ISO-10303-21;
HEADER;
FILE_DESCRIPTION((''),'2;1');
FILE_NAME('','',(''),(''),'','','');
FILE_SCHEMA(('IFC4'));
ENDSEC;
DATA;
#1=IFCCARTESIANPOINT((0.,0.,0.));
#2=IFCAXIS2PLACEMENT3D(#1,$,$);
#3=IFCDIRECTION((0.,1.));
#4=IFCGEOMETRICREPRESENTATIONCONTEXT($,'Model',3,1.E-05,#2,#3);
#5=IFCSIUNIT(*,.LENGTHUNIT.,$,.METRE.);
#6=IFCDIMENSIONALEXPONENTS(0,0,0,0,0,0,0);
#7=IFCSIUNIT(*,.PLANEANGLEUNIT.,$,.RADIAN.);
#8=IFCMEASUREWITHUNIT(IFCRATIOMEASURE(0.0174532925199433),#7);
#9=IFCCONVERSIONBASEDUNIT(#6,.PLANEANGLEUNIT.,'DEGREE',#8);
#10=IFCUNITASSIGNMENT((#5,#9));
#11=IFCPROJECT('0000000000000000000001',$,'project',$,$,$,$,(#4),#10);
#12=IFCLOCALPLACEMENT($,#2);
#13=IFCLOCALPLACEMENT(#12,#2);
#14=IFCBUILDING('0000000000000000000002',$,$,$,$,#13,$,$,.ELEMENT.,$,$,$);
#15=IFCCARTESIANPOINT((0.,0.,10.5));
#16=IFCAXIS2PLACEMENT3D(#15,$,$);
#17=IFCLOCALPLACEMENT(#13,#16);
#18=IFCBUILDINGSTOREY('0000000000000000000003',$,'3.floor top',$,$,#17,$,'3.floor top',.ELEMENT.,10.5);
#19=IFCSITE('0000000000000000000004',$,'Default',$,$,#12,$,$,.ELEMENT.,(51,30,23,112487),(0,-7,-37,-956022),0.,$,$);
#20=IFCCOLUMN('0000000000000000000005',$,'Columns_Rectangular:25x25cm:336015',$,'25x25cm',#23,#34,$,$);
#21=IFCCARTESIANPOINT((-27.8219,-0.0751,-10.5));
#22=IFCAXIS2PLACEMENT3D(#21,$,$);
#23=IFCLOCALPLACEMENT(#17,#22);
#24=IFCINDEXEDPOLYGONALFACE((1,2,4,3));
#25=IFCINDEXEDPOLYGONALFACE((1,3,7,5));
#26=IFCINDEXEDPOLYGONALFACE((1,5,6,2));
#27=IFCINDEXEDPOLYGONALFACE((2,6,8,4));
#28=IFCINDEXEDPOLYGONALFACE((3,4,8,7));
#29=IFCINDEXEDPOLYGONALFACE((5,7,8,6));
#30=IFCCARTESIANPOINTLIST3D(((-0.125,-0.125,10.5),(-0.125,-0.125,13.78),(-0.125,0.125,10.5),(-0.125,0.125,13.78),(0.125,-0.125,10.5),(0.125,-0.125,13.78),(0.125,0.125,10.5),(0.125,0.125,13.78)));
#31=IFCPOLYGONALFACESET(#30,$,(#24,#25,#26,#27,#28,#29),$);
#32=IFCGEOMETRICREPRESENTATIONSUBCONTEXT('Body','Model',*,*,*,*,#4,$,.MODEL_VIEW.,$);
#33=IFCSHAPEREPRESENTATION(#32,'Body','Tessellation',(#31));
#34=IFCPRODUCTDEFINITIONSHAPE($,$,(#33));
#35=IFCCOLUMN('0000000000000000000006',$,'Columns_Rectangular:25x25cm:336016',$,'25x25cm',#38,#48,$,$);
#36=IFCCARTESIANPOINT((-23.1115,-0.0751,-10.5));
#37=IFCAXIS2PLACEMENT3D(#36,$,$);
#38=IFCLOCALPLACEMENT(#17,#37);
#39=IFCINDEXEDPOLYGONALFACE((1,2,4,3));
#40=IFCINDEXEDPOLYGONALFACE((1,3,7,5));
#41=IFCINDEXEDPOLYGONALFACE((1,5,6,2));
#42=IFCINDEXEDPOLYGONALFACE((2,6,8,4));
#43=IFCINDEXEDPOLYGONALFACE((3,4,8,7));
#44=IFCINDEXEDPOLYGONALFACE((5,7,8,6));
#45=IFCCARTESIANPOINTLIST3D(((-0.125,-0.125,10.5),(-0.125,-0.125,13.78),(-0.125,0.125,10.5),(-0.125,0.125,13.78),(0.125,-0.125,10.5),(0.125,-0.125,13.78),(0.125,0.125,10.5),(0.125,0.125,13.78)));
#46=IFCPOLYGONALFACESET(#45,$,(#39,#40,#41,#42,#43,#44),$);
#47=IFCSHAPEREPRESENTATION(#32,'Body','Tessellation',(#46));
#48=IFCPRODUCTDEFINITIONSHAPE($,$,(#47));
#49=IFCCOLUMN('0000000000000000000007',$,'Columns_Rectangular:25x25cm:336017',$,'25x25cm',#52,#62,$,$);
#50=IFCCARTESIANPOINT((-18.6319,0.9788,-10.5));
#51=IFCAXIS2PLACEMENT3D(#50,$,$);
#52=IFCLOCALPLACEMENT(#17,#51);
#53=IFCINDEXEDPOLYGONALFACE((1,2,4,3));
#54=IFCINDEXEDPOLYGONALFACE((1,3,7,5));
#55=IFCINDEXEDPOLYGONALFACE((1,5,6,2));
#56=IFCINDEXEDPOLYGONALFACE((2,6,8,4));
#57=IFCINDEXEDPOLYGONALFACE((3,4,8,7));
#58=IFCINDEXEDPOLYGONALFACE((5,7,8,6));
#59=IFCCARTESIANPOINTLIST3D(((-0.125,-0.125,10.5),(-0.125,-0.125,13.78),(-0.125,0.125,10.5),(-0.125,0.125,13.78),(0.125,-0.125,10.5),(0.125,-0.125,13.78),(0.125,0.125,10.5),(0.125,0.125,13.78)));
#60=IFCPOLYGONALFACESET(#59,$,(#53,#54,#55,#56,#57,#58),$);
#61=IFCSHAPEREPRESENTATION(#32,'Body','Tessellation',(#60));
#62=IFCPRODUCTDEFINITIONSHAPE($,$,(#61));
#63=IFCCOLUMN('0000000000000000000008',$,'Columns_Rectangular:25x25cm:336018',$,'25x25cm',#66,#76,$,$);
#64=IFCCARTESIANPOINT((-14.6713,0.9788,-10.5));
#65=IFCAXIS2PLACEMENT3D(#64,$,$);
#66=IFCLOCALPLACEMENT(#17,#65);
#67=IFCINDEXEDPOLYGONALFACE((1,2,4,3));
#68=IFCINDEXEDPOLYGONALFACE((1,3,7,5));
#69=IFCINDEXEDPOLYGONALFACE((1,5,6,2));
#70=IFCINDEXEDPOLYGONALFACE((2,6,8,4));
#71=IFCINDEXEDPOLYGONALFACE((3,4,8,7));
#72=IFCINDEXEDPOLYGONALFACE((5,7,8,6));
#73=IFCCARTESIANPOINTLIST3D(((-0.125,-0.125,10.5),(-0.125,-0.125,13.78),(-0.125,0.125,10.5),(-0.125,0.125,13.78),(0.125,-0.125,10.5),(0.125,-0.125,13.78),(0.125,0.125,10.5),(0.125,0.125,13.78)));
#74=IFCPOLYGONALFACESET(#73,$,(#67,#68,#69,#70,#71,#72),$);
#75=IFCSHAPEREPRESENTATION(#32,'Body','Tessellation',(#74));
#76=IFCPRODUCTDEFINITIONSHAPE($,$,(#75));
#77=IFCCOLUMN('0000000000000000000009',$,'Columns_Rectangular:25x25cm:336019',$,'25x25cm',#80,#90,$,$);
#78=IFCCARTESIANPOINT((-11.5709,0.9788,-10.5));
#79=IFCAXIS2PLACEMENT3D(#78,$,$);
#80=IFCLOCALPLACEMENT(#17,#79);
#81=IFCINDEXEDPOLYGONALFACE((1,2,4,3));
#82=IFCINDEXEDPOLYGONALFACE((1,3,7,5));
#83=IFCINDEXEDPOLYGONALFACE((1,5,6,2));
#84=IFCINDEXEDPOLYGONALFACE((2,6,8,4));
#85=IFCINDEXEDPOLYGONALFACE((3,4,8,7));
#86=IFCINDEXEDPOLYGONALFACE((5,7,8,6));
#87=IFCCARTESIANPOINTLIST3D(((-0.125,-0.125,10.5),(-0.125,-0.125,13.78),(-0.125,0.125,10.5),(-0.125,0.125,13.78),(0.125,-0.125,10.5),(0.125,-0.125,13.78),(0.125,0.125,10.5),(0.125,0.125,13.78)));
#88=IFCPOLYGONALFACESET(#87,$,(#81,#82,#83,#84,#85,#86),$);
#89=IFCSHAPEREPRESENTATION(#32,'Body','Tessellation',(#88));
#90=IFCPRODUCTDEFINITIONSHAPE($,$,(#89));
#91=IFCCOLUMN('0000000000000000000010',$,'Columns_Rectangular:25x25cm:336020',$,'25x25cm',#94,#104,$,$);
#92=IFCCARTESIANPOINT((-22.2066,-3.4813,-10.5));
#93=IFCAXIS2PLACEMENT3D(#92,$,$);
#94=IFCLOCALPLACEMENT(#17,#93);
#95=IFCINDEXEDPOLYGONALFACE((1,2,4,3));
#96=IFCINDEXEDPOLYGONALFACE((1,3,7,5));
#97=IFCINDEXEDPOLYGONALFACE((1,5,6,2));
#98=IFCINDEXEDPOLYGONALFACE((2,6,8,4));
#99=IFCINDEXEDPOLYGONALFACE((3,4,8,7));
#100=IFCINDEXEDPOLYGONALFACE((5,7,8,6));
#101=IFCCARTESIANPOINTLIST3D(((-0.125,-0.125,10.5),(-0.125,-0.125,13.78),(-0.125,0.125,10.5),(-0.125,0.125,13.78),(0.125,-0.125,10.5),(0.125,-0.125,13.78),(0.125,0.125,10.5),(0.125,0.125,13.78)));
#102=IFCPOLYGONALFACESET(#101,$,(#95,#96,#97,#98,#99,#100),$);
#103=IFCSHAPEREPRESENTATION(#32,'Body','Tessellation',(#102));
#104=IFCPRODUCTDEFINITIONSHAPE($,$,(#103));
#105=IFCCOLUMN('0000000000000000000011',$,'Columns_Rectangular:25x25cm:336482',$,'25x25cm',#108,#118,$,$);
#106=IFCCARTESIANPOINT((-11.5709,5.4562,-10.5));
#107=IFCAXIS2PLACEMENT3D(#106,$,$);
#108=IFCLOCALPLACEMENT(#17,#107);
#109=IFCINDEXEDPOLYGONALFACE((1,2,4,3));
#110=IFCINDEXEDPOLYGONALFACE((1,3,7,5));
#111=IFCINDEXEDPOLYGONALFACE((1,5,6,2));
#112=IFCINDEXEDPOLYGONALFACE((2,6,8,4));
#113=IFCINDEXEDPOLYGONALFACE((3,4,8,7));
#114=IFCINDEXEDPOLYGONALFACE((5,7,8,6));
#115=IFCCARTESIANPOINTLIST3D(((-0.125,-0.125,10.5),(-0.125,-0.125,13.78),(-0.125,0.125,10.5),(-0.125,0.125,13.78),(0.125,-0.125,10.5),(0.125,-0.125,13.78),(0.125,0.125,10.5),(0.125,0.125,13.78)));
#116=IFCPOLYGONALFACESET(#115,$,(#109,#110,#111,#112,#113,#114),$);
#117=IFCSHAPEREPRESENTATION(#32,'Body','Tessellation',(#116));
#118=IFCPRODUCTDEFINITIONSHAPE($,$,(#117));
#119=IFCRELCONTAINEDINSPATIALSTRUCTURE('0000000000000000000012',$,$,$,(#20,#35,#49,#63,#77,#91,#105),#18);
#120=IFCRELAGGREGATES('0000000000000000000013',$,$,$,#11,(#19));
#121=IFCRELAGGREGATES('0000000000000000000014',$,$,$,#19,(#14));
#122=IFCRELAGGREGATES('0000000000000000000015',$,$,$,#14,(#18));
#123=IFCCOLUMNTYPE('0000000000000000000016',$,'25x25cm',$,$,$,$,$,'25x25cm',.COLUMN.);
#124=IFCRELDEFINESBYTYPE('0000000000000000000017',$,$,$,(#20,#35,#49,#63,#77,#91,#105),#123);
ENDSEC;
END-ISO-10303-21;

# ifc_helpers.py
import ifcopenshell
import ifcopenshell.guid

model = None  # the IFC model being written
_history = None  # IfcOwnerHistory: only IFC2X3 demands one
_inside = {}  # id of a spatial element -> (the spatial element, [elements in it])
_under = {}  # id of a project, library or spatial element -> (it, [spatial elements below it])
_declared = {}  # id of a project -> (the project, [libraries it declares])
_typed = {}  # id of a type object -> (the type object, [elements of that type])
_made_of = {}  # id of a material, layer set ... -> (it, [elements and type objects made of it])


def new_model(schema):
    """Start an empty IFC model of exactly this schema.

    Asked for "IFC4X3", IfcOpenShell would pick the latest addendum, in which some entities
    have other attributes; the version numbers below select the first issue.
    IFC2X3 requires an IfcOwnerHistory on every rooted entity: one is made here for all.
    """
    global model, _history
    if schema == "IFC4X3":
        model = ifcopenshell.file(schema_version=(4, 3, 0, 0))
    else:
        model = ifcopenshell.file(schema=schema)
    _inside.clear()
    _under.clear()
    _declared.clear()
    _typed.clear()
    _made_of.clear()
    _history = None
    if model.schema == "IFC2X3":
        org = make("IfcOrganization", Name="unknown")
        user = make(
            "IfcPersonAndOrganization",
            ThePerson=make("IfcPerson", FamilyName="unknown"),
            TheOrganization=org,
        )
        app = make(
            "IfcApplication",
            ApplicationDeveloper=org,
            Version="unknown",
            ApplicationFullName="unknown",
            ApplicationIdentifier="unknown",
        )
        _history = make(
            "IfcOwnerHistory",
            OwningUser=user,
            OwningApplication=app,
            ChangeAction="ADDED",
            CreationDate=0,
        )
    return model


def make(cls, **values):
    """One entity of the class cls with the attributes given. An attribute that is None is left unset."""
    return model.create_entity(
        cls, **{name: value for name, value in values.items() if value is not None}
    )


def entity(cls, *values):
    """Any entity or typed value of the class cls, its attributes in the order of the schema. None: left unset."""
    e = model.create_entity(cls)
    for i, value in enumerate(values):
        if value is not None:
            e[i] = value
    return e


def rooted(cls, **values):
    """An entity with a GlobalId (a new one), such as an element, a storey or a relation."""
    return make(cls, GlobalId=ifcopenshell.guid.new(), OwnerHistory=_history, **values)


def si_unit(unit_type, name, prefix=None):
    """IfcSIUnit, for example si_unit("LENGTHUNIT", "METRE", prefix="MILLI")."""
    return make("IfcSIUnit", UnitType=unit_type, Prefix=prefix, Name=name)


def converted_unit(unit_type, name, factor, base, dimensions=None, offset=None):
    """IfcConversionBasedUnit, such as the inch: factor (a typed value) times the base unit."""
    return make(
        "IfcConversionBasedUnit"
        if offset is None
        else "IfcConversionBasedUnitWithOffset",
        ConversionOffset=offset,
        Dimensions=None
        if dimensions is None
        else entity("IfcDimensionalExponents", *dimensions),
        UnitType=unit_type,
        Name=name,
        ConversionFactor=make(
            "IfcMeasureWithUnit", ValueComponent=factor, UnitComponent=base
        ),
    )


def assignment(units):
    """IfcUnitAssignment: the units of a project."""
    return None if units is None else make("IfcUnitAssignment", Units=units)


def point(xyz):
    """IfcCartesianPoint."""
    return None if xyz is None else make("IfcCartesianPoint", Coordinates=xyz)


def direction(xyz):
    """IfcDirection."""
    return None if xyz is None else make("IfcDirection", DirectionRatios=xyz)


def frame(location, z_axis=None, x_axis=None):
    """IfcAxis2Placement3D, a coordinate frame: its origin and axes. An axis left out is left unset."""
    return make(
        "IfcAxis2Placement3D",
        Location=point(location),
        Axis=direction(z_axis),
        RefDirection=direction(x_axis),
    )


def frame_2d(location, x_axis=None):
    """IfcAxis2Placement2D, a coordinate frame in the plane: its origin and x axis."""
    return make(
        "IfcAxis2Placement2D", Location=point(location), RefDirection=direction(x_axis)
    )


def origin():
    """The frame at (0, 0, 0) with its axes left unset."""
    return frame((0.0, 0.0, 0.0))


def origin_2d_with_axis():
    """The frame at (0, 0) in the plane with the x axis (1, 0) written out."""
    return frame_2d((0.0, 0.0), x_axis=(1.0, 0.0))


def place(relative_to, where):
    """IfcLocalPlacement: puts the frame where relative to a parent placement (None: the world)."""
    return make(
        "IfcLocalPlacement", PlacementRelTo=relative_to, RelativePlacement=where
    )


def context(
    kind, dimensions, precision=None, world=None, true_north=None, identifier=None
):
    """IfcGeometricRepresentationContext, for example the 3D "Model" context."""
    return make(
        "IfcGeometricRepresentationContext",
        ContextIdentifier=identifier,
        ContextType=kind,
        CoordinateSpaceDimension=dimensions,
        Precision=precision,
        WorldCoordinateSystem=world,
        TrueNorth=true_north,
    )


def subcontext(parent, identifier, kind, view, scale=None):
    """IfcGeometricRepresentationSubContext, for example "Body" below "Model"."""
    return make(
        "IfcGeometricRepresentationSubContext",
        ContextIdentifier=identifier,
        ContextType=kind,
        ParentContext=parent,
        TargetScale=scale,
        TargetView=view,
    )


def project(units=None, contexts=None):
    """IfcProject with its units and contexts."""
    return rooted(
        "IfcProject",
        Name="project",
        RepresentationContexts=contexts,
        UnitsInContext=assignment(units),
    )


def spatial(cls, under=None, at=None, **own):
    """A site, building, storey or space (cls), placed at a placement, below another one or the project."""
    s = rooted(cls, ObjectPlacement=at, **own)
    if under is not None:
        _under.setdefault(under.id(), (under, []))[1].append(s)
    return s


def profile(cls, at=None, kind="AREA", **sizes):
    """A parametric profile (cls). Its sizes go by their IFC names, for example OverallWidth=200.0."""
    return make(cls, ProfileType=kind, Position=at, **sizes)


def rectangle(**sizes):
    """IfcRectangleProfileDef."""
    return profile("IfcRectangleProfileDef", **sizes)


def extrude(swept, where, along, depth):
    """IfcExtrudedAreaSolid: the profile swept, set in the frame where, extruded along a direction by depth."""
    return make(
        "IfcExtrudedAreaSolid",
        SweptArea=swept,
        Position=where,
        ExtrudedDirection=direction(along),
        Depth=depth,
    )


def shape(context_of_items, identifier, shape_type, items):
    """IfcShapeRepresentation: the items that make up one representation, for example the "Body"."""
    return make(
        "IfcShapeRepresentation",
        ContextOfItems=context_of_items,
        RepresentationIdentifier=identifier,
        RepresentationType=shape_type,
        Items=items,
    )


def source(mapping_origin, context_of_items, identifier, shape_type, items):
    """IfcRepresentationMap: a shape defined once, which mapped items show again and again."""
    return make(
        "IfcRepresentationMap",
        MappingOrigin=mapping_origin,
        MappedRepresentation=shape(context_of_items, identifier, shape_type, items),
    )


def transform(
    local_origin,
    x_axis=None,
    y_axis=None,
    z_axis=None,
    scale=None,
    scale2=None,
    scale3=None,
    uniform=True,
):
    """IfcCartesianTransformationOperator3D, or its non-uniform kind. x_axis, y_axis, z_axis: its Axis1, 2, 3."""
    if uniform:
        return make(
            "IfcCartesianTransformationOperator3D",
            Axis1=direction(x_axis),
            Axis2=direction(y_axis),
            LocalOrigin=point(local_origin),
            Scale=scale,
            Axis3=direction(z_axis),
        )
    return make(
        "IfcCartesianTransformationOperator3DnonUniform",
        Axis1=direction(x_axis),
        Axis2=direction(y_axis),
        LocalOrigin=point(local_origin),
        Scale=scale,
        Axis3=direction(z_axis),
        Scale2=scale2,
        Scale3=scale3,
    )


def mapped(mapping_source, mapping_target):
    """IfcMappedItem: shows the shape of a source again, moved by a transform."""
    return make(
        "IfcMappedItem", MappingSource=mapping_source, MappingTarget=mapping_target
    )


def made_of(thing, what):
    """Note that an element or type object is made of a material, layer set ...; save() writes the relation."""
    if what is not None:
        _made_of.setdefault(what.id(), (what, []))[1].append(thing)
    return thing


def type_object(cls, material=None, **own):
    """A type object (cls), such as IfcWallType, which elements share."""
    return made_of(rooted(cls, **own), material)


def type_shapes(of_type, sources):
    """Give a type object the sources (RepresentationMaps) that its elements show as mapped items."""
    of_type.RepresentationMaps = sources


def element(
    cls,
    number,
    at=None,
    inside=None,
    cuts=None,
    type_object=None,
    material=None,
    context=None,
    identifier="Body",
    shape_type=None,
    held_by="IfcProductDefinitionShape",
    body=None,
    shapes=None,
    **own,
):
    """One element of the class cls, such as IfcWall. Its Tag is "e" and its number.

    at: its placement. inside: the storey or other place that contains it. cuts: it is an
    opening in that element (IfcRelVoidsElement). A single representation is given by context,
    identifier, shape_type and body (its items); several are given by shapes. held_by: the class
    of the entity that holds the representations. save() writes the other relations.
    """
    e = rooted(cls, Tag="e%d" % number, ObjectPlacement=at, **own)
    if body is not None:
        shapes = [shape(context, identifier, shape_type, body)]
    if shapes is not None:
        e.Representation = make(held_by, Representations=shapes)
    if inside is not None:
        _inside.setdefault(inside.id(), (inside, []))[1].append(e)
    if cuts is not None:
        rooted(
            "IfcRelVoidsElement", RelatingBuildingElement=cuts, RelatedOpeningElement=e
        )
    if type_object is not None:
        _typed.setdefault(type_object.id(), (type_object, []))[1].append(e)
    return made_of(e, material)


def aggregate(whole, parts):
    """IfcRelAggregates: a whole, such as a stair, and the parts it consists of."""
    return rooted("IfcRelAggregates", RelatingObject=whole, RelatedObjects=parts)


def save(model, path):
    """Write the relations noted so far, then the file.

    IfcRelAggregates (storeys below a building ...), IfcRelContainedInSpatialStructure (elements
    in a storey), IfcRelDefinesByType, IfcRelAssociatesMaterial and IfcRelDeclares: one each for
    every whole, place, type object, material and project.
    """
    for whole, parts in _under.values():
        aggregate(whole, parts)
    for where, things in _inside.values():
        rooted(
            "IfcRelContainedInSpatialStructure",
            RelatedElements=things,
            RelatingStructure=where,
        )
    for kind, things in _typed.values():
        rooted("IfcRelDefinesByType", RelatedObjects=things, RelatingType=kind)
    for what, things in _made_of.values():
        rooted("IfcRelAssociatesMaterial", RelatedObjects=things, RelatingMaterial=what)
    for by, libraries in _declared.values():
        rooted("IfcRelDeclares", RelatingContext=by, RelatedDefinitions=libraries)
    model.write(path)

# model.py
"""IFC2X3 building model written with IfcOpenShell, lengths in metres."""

from ifc_helpers import new_model, entity, si_unit, converted_unit, direction, frame, origin, origin_2d_with_axis, place, context, subcontext, project, spatial, rectangle, extrude, source, transform, mapped, type_object, type_shapes, element, save


model = new_model("IFC2X3")

# Units and contexts
model_context = context("Model", 3, precision=1e-05, world=origin(), true_north=direction((0.0, 1.0)))
body_context = subcontext(model_context, "Body", "Model", "MODEL_VIEW")
ifc_project = project(units=[si_unit("LENGTHUNIT", "METRE"), converted_unit("PLANEANGLEUNIT", "DEGREE", entity("IfcRatioMeasure", 0.0174532925199433), si_unit("PLANEANGLEUNIT", "RADIAN"), dimensions=[0, 0, 0, 0, 0, 0, 0])], contexts=[model_context])

# Site, building, storey
site_placement = place(None, origin())
site = spatial("IfcSite", under=ifc_project, at=site_placement, Name="Default", CompositionType="ELEMENT", RefLatitude=(51, 30, 23, 112487), RefLongitude=(0, -7, -37, -956022), RefElevation=0.0)
building_placement = place(site_placement, origin())
building = spatial("IfcBuilding", under=site, at=building_placement, CompositionType="ELEMENT")
storey_placement = place(building_placement, frame((0.0, 0.0, 10.5)))
storey = spatial("IfcBuildingStorey", under=building, at=storey_placement, Name="3.floor top", LongName="3.floor top", CompositionType="ELEMENT", Elevation=10.5)

# Columns
column_type = type_object("IfcColumnType", Name="25x25cm", ElementType="25x25cm", PredefinedType="COLUMN")
shared_shape = source(origin(), body_context, "Body", "SweptSolid", [
    extrude(rectangle(XDim=0.25, YDim=0.25, at=origin_2d_with_axis()), frame((0.0, 0.0, 10.5), z_axis=(0.0, 0.0, 1.0), x_axis=(0.0, -1.0, 0.0)), (0.0, 0.0, 1.0), 3.28),
])
type_shapes(column_type, [shared_shape])
for number, where, name in (
    (1, (-27.8219, -0.0751, -10.5), "Columns_Rectangular:25x25cm:336015"),
    (2, (-23.1115, -0.0751, -10.5), "Columns_Rectangular:25x25cm:336016"),
    (3, (-18.6319, 0.9788, -10.5), "Columns_Rectangular:25x25cm:336017"),
    (4, (-14.6713, 0.9788, -10.5), "Columns_Rectangular:25x25cm:336018"),
    (5, (-11.5709, 0.9788, -10.5), "Columns_Rectangular:25x25cm:336019"),
    (6, (-22.2066, -3.4813, -10.5), "Columns_Rectangular:25x25cm:336020"),
    (7, (-11.5709, 5.4562, -10.5), "Columns_Rectangular:25x25cm:336482"),
):
    element("IfcColumn", number, at=place(storey_placement, frame(where)), inside=storey, type_object=column_type, Name=name, ObjectType="25x25cm", context=body_context, shape_type="MappedRepresentation", body=[
        mapped(shared_shape, transform((0.0, 0.0, 0.0), scale=1.0)),
    ])

save(model, "model.ifc")
